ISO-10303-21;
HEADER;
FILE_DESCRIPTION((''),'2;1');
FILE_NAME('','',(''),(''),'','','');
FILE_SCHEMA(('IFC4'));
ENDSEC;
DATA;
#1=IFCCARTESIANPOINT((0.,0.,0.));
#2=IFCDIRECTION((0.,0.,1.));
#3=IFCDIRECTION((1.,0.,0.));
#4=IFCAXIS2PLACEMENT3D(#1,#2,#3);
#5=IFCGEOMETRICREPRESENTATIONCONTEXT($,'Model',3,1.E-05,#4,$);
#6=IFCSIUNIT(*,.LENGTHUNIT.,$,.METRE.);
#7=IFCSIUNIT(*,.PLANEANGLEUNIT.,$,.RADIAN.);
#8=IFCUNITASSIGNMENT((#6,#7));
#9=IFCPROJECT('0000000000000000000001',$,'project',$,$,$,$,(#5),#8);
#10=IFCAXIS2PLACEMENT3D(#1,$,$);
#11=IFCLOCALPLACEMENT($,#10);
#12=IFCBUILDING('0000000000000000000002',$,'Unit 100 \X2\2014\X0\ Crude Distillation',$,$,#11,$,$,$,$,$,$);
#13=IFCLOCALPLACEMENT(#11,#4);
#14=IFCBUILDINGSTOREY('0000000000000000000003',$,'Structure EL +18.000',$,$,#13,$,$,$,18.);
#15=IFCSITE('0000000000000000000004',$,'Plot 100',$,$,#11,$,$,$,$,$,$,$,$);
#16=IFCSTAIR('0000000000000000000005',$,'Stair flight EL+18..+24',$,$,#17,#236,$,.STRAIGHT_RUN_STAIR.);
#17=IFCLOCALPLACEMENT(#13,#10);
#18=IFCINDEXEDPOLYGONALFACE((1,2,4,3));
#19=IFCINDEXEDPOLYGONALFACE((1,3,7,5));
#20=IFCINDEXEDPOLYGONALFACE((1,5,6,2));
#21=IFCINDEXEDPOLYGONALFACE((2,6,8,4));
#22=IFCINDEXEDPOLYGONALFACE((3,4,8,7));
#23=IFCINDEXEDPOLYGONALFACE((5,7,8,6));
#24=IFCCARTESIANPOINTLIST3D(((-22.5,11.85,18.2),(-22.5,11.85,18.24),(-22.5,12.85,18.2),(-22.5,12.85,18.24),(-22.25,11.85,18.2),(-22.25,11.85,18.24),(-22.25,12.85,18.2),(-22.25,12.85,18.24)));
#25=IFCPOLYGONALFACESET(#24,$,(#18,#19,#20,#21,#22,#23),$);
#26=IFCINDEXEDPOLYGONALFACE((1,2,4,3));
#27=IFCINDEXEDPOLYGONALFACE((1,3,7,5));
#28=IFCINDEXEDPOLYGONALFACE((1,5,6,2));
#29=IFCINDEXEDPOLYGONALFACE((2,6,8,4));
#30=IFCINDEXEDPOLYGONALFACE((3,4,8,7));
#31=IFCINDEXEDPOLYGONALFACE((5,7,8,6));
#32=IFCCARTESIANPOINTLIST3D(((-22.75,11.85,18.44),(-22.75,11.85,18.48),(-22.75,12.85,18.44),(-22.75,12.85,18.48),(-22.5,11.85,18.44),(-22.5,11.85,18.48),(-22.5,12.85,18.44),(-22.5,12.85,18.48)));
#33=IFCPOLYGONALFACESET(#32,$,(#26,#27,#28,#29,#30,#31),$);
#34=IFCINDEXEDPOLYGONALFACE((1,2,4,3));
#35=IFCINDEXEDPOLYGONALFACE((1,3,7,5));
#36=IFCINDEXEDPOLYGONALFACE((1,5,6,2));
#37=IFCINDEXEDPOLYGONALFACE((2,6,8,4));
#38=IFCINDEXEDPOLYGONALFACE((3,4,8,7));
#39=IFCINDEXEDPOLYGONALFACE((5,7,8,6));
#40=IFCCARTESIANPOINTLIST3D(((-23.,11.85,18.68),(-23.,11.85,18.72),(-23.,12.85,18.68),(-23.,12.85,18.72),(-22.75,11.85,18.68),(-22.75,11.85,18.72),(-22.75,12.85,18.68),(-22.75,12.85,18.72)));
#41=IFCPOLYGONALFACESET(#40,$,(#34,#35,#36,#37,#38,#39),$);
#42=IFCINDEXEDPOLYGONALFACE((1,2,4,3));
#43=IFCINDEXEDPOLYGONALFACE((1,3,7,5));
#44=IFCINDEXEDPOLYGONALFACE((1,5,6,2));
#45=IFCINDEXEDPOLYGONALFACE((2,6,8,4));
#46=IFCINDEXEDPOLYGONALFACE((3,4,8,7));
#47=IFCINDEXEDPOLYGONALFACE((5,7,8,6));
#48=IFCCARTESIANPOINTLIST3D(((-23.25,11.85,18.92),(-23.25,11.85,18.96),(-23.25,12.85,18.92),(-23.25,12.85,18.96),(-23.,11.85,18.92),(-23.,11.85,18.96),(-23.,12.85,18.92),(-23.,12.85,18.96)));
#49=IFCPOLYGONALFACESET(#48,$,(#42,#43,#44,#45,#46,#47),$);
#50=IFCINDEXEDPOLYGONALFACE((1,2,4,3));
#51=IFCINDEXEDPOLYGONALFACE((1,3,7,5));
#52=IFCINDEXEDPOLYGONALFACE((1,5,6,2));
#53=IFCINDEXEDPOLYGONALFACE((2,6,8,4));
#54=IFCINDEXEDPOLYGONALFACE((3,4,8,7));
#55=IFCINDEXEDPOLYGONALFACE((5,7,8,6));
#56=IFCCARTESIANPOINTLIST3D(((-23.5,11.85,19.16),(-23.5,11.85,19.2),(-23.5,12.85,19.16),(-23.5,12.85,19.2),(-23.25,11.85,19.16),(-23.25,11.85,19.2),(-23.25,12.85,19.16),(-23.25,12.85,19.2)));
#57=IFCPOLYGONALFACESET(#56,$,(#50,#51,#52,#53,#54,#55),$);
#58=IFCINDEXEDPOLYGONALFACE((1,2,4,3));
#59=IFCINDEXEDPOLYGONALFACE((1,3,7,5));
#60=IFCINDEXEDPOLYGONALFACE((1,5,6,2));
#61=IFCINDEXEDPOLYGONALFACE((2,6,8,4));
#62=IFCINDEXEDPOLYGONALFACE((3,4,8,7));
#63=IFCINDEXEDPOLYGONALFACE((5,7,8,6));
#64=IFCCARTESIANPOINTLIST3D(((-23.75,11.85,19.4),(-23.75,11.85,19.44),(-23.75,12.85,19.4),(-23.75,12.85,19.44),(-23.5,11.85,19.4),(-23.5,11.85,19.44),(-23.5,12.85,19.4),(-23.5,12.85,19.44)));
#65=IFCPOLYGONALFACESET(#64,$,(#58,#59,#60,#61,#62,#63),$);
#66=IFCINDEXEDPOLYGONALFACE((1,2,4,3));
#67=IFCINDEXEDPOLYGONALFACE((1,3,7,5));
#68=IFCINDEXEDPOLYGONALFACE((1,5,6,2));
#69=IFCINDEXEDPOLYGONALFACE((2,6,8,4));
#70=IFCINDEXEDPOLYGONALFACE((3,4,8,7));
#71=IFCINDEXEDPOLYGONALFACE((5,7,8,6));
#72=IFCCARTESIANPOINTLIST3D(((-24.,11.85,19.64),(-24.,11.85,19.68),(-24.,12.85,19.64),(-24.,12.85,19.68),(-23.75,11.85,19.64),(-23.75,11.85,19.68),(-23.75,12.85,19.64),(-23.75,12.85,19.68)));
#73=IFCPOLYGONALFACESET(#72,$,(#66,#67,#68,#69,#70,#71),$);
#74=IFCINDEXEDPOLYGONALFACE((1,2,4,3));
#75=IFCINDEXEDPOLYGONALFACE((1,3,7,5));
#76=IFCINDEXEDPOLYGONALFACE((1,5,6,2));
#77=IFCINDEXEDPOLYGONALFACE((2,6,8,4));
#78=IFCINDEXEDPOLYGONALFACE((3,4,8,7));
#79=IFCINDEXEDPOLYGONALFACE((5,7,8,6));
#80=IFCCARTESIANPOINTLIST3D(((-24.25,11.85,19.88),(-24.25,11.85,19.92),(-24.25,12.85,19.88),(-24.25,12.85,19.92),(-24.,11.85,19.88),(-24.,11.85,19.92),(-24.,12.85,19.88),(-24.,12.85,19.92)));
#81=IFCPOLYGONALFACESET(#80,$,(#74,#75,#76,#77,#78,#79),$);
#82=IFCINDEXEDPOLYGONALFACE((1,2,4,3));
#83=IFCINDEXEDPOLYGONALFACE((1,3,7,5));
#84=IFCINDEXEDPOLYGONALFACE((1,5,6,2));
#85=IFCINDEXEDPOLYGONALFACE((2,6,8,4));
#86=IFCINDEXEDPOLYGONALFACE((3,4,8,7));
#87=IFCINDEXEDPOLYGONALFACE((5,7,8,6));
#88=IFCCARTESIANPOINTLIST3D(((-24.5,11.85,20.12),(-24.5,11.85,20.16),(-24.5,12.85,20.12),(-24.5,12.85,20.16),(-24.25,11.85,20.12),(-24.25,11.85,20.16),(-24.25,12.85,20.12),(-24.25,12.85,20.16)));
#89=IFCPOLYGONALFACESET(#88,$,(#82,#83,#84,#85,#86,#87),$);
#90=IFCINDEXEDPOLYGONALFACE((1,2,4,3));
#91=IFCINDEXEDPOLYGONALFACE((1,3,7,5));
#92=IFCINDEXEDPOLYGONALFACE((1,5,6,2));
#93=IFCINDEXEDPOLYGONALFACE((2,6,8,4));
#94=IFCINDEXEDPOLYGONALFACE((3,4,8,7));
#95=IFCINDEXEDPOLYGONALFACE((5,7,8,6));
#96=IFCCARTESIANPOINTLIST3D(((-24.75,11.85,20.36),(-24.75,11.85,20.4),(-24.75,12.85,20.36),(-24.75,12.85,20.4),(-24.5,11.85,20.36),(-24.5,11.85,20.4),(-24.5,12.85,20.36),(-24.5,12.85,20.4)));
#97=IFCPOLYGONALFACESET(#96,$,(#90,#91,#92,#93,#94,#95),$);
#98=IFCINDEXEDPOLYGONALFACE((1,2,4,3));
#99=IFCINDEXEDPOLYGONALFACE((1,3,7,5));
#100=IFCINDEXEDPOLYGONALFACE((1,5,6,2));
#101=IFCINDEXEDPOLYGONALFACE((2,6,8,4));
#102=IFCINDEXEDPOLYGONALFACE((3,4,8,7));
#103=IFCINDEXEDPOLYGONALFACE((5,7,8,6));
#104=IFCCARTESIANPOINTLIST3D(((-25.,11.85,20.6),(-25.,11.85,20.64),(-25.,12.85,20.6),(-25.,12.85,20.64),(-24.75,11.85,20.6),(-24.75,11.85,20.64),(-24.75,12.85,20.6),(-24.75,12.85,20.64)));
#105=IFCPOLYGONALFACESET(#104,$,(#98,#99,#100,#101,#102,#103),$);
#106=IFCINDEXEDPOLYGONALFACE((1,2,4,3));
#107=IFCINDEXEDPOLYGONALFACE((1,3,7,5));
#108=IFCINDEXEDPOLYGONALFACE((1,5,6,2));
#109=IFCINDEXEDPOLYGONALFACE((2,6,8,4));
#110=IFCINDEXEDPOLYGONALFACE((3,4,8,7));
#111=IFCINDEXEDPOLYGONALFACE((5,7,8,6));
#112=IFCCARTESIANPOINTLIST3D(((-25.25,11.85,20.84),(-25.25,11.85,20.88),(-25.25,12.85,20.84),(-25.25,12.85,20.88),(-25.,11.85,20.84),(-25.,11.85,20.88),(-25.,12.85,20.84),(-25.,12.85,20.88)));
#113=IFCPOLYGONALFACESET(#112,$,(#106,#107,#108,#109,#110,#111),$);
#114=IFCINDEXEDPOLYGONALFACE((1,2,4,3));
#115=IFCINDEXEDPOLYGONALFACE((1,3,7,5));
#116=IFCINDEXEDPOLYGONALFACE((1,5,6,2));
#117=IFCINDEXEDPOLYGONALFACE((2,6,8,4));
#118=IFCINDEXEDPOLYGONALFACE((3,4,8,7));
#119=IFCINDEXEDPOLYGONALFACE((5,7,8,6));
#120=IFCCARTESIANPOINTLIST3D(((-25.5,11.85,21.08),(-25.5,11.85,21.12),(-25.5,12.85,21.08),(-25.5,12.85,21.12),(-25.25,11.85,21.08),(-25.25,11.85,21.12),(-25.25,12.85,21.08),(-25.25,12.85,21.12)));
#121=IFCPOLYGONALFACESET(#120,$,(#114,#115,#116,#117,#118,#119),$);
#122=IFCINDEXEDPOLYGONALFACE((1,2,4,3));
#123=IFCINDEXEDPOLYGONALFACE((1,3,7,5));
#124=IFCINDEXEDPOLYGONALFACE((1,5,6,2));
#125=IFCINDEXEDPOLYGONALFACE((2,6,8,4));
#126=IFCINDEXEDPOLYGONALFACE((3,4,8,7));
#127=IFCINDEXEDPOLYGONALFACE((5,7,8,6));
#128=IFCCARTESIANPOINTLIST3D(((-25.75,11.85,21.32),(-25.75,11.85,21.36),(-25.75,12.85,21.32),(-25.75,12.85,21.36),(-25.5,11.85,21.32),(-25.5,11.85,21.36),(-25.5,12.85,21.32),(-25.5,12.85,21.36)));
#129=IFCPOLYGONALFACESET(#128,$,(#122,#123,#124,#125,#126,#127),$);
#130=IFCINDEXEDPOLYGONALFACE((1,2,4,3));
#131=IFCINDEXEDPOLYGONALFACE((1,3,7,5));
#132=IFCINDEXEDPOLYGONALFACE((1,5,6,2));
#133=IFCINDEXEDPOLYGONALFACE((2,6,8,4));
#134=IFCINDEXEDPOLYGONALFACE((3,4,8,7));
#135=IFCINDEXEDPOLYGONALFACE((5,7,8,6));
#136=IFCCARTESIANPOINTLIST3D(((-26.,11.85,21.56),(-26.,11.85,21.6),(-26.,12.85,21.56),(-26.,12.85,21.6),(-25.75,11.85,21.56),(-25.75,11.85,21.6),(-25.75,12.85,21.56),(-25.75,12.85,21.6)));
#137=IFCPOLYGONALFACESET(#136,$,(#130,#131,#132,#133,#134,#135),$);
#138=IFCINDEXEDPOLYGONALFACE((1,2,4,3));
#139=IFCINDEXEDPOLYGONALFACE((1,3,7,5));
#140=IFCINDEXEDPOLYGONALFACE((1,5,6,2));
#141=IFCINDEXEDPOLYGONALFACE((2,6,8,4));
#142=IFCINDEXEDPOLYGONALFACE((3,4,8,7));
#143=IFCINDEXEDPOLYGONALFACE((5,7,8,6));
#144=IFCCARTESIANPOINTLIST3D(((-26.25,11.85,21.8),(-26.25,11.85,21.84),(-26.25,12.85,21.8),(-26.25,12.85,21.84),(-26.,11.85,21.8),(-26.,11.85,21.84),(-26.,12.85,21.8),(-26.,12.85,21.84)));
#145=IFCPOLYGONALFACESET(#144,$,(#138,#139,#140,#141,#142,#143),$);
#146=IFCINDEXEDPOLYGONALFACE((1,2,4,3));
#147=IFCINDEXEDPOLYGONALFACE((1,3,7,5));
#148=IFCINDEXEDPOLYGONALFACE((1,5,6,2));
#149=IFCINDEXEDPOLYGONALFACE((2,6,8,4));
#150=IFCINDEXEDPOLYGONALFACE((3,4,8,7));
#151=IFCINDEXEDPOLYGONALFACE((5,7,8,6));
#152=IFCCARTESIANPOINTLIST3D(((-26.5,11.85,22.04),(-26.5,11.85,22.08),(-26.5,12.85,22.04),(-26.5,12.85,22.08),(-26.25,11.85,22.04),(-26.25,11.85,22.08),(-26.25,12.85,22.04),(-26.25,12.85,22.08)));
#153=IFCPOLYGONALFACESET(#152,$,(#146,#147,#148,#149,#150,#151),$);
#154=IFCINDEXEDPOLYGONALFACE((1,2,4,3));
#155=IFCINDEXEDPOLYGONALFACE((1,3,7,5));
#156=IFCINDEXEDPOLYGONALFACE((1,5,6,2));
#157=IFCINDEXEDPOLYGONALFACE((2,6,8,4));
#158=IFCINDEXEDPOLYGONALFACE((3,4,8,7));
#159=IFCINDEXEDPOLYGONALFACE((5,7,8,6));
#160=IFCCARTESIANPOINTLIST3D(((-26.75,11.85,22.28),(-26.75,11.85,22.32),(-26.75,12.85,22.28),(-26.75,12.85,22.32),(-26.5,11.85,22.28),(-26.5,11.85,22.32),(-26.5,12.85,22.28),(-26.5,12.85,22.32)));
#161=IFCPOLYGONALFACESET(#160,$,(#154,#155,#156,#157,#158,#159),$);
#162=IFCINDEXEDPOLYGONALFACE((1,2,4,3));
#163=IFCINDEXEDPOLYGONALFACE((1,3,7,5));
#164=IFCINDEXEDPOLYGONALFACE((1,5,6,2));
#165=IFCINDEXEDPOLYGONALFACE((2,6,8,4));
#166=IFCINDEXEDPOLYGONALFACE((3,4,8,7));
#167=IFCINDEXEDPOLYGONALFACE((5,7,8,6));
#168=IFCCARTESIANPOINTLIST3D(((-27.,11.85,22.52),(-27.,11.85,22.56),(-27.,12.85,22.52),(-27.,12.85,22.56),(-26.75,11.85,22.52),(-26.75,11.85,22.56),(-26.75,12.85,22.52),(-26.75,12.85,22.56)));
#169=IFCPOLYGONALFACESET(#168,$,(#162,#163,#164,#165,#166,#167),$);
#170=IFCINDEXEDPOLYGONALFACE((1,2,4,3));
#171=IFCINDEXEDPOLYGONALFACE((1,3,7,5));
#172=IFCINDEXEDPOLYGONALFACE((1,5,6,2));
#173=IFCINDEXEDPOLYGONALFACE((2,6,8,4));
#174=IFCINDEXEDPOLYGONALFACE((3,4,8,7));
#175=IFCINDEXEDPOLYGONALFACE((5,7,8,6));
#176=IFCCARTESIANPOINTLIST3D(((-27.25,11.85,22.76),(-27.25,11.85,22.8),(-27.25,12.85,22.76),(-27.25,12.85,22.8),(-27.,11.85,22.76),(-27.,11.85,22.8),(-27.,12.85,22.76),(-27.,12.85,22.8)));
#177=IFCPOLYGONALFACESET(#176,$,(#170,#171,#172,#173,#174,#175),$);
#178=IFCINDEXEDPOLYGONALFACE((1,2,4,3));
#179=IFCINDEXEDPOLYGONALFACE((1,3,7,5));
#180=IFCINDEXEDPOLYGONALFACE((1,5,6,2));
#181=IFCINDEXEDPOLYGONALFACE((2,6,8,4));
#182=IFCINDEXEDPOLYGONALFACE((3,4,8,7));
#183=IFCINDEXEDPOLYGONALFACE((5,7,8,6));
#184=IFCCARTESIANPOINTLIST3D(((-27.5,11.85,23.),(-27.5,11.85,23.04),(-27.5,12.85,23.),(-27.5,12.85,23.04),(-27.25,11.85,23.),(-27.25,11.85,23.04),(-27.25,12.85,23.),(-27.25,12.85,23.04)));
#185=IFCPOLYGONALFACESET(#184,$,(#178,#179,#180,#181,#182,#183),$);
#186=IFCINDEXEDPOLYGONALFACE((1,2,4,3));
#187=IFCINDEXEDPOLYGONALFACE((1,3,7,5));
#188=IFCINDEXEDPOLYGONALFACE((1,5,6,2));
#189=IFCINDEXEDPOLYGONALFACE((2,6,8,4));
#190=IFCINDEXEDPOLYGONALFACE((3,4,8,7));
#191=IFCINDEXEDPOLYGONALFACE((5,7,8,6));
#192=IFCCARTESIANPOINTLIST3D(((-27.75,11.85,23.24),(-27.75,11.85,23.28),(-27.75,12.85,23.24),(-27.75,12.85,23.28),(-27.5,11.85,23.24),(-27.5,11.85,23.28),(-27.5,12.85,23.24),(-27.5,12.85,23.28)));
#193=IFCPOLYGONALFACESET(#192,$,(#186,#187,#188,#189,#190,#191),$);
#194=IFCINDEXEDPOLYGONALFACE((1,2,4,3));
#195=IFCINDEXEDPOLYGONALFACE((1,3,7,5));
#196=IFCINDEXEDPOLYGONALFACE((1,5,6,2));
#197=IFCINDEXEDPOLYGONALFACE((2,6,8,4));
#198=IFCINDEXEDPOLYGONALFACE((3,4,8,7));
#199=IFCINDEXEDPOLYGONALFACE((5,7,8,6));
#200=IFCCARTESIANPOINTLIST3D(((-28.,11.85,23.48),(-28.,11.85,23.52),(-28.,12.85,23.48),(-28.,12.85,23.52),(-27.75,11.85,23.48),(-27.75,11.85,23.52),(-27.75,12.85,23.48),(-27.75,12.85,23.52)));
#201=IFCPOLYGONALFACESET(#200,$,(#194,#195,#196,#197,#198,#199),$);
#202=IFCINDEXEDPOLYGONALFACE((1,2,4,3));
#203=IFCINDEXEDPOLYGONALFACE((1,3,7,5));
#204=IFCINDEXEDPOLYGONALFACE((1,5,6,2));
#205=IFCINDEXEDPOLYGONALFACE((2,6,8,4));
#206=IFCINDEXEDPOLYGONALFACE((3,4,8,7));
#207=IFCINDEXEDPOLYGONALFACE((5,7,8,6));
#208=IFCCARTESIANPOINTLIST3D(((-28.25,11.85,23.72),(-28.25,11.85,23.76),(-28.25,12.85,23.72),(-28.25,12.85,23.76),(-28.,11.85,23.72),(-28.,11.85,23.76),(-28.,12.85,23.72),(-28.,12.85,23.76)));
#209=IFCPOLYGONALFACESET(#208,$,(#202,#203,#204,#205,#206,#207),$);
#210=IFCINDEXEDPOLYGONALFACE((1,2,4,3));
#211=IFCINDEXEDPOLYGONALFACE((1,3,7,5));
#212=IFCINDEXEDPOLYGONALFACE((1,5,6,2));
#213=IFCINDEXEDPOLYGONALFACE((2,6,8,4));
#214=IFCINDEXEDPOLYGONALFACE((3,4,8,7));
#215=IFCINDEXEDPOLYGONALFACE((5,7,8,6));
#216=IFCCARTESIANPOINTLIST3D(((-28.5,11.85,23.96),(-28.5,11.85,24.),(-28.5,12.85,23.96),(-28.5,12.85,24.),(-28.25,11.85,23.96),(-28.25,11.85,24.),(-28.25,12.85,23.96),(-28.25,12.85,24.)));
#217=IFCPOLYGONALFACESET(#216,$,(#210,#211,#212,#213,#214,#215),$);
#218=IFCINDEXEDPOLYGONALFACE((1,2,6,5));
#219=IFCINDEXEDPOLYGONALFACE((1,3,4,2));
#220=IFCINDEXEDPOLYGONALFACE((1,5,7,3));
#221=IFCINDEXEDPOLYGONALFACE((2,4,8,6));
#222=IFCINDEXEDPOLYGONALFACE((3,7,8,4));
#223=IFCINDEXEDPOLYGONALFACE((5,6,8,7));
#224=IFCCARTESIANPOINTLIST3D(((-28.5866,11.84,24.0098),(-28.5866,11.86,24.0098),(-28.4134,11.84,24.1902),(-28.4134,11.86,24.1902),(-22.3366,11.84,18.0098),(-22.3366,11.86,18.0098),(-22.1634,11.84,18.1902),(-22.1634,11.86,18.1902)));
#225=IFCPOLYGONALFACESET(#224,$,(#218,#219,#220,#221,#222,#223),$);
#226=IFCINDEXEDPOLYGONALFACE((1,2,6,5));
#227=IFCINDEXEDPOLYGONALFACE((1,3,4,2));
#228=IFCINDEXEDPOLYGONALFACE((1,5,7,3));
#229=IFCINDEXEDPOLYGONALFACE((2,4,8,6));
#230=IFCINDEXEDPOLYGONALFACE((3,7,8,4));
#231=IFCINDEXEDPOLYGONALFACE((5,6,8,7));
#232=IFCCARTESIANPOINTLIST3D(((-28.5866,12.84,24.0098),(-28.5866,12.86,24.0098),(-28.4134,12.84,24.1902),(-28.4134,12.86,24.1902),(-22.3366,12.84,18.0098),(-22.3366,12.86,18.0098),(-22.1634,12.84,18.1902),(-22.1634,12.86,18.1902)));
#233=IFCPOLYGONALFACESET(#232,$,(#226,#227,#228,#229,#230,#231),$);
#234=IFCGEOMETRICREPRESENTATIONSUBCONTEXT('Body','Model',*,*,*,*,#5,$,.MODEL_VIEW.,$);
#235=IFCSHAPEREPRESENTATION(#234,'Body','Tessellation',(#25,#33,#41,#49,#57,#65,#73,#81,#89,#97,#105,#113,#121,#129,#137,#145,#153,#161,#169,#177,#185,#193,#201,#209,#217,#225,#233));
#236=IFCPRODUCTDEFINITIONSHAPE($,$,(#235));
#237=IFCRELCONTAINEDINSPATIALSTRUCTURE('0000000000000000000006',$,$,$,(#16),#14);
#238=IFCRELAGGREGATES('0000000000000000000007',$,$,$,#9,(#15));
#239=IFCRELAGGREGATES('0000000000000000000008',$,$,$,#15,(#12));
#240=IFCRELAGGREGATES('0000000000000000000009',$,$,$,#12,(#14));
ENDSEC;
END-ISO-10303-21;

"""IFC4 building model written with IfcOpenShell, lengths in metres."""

from ifc_helpers import new_model, si_unit, frame, origin, origin_with_axes, origin_2d, place, context, subcontext, project, spatial, rectangle, extrude, element, save


model = new_model("IFC4")

# Units and contexts
model_context = context("Model", 3, precision=1e-05, world=origin_with_axes())
body_context = subcontext(model_context, "Body", "Model", "MODEL_VIEW")
ifc_project = project(units=[si_unit("LENGTHUNIT", "METRE"), si_unit("PLANEANGLEUNIT", "RADIAN")], contexts=[model_context])

# Site, building, storey
placement = place(None, origin())
site = spatial("IfcSite", under=ifc_project, at=placement, Name="Plot 100")
building = spatial("IfcBuilding", under=site, at=placement, Name="Unit 100 — Crude Distillation")
storey_placement = place(placement, origin_with_axes())
storey = spatial("IfcBuildingStorey", under=building, at=storey_placement, Name="Structure EL +18.000", Elevation=18.0)

# Stair
stair_placement = place(storey_placement, origin_with_axes())
element("IfcStair", 1, at=stair_placement, inside=storey, Name="Stair flight EL+18..+24", PredefinedType="STRAIGHT_RUN_STAIR", context=body_context, shape_type="SweptSolid", body=[
    extrude(rectangle(XDim=0.25, YDim=1.0, at=origin_2d()), frame((-22.375, 12.35, 18.2), z_axis=(0.0, 0.0, 1.0), x_axis=(1.0, 0.0, 0.0)), (0.0, 0.0, 1.0), 0.04),
    extrude(rectangle(XDim=0.25, YDim=1.0, at=origin_2d()), frame((-22.625, 12.35, 18.44), z_axis=(0.0, 0.0, 1.0), x_axis=(1.0, 0.0, 0.0)), (0.0, 0.0, 1.0), 0.04),
    extrude(rectangle(XDim=0.25, YDim=1.0, at=origin_2d()), frame((-22.875, 12.35, 18.68), z_axis=(0.0, 0.0, 1.0), x_axis=(1.0, 0.0, 0.0)), (0.0, 0.0, 1.0), 0.04),
    extrude(rectangle(XDim=0.25, YDim=1.0, at=origin_2d()), frame((-23.125, 12.35, 18.92), z_axis=(0.0, 0.0, 1.0), x_axis=(1.0, 0.0, 0.0)), (0.0, 0.0, 1.0), 0.04),
    extrude(rectangle(XDim=0.25, YDim=1.0, at=origin_2d()), frame((-23.375, 12.35, 19.16), z_axis=(0.0, 0.0, 1.0), x_axis=(1.0, 0.0, 0.0)), (0.0, 0.0, 1.0), 0.04),
    extrude(rectangle(XDim=0.25, YDim=1.0, at=origin_2d()), frame((-23.625, 12.35, 19.4), z_axis=(0.0, 0.0, 1.0), x_axis=(1.0, 0.0, 0.0)), (0.0, 0.0, 1.0), 0.04),
    extrude(rectangle(XDim=0.25, YDim=1.0, at=origin_2d()), frame((-23.875, 12.35, 19.64), z_axis=(0.0, 0.0, 1.0), x_axis=(1.0, 0.0, 0.0)), (0.0, 0.0, 1.0), 0.04),
    extrude(rectangle(XDim=0.25, YDim=1.0, at=origin_2d()), frame((-24.125, 12.35, 19.88), z_axis=(0.0, 0.0, 1.0), x_axis=(1.0, 0.0, 0.0)), (0.0, 0.0, 1.0), 0.04),
    extrude(rectangle(XDim=0.25, YDim=1.0, at=origin_2d()), frame((-24.375, 12.35, 20.12), z_axis=(0.0, 0.0, 1.0), x_axis=(1.0, 0.0, 0.0)), (0.0, 0.0, 1.0), 0.04),
    extrude(rectangle(XDim=0.25, YDim=1.0, at=origin_2d()), frame((-24.625, 12.35, 20.36), z_axis=(0.0, 0.0, 1.0), x_axis=(1.0, 0.0, 0.0)), (0.0, 0.0, 1.0), 0.04),
    extrude(rectangle(XDim=0.25, YDim=1.0, at=origin_2d()), frame((-24.875, 12.35, 20.6), z_axis=(0.0, 0.0, 1.0), x_axis=(1.0, 0.0, 0.0)), (0.0, 0.0, 1.0), 0.04),
    extrude(rectangle(XDim=0.25, YDim=1.0, at=origin_2d()), frame((-25.125, 12.35, 20.84), z_axis=(0.0, 0.0, 1.0), x_axis=(1.0, 0.0, 0.0)), (0.0, 0.0, 1.0), 0.04),
    extrude(rectangle(XDim=0.25, YDim=1.0, at=origin_2d()), frame((-25.375, 12.35, 21.08), z_axis=(0.0, 0.0, 1.0), x_axis=(1.0, 0.0, 0.0)), (0.0, 0.0, 1.0), 0.04),
    extrude(rectangle(XDim=0.25, YDim=1.0, at=origin_2d()), frame((-25.625, 12.35, 21.32), z_axis=(0.0, 0.0, 1.0), x_axis=(1.0, 0.0, 0.0)), (0.0, 0.0, 1.0), 0.04),
    extrude(rectangle(XDim=0.25, YDim=1.0, at=origin_2d()), frame((-25.875, 12.35, 21.56), z_axis=(0.0, 0.0, 1.0), x_axis=(1.0, 0.0, 0.0)), (0.0, 0.0, 1.0), 0.04),
    extrude(rectangle(XDim=0.25, YDim=1.0, at=origin_2d()), frame((-26.125, 12.35, 21.8), z_axis=(0.0, 0.0, 1.0), x_axis=(1.0, 0.0, 0.0)), (0.0, 0.0, 1.0), 0.04),
    extrude(rectangle(XDim=0.25, YDim=1.0, at=origin_2d()), frame((-26.375, 12.35, 22.04), z_axis=(0.0, 0.0, 1.0), x_axis=(1.0, 0.0, 0.0)), (0.0, 0.0, 1.0), 0.04),
    extrude(rectangle(XDim=0.25, YDim=1.0, at=origin_2d()), frame((-26.625, 12.35, 22.28), z_axis=(0.0, 0.0, 1.0), x_axis=(1.0, 0.0, 0.0)), (0.0, 0.0, 1.0), 0.04),
    extrude(rectangle(XDim=0.25, YDim=1.0, at=origin_2d()), frame((-26.875, 12.35, 22.52), z_axis=(0.0, 0.0, 1.0), x_axis=(1.0, 0.0, 0.0)), (0.0, 0.0, 1.0), 0.04),
    extrude(rectangle(XDim=0.25, YDim=1.0, at=origin_2d()), frame((-27.125, 12.35, 22.76), z_axis=(0.0, 0.0, 1.0), x_axis=(1.0, 0.0, 0.0)), (0.0, 0.0, 1.0), 0.04),
    extrude(rectangle(XDim=0.25, YDim=1.0, at=origin_2d()), frame((-27.375, 12.35, 23.0), z_axis=(0.0, 0.0, 1.0), x_axis=(1.0, 0.0, 0.0)), (0.0, 0.0, 1.0), 0.04),
    extrude(rectangle(XDim=0.25, YDim=1.0, at=origin_2d()), frame((-27.625, 12.35, 23.24), z_axis=(0.0, 0.0, 1.0), x_axis=(1.0, 0.0, 0.0)), (0.0, 0.0, 1.0), 0.04),
    extrude(rectangle(XDim=0.25, YDim=1.0, at=origin_2d()), frame((-27.875, 12.35, 23.48), z_axis=(0.0, 0.0, 1.0), x_axis=(1.0, 0.0, 0.0)), (0.0, 0.0, 1.0), 0.04),
    extrude(rectangle(XDim=0.25, YDim=1.0, at=origin_2d()), frame((-28.125, 12.35, 23.72), z_axis=(0.0, 0.0, 1.0), x_axis=(1.0, 0.0, 0.0)), (0.0, 0.0, 1.0), 0.04),
    extrude(rectangle(XDim=0.25, YDim=1.0, at=origin_2d()), frame((-28.375, 12.35, 23.96), z_axis=(0.0, 0.0, 1.0), x_axis=(1.0, 0.0, 0.0)), (0.0, 0.0, 1.0), 0.04),
    extrude(rectangle(XDim=0.02, YDim=0.25, at=origin_2d()), frame((-22.25, 11.85, 18.1), z_axis=(-0.721387, 0.0, 0.692532), x_axis=(0.0, -1.0, 0.0)), (0.0, 0.0, 1.0), 8.6639),
    extrude(rectangle(XDim=0.02, YDim=0.25, at=origin_2d()), frame((-22.25, 12.85, 18.1), z_axis=(-0.721387, 0.0, 0.692532), x_axis=(0.0, -1.0, 0.0)), (0.0, 0.0, 1.0), 8.6639),
])

save(model, "model.ifc")
